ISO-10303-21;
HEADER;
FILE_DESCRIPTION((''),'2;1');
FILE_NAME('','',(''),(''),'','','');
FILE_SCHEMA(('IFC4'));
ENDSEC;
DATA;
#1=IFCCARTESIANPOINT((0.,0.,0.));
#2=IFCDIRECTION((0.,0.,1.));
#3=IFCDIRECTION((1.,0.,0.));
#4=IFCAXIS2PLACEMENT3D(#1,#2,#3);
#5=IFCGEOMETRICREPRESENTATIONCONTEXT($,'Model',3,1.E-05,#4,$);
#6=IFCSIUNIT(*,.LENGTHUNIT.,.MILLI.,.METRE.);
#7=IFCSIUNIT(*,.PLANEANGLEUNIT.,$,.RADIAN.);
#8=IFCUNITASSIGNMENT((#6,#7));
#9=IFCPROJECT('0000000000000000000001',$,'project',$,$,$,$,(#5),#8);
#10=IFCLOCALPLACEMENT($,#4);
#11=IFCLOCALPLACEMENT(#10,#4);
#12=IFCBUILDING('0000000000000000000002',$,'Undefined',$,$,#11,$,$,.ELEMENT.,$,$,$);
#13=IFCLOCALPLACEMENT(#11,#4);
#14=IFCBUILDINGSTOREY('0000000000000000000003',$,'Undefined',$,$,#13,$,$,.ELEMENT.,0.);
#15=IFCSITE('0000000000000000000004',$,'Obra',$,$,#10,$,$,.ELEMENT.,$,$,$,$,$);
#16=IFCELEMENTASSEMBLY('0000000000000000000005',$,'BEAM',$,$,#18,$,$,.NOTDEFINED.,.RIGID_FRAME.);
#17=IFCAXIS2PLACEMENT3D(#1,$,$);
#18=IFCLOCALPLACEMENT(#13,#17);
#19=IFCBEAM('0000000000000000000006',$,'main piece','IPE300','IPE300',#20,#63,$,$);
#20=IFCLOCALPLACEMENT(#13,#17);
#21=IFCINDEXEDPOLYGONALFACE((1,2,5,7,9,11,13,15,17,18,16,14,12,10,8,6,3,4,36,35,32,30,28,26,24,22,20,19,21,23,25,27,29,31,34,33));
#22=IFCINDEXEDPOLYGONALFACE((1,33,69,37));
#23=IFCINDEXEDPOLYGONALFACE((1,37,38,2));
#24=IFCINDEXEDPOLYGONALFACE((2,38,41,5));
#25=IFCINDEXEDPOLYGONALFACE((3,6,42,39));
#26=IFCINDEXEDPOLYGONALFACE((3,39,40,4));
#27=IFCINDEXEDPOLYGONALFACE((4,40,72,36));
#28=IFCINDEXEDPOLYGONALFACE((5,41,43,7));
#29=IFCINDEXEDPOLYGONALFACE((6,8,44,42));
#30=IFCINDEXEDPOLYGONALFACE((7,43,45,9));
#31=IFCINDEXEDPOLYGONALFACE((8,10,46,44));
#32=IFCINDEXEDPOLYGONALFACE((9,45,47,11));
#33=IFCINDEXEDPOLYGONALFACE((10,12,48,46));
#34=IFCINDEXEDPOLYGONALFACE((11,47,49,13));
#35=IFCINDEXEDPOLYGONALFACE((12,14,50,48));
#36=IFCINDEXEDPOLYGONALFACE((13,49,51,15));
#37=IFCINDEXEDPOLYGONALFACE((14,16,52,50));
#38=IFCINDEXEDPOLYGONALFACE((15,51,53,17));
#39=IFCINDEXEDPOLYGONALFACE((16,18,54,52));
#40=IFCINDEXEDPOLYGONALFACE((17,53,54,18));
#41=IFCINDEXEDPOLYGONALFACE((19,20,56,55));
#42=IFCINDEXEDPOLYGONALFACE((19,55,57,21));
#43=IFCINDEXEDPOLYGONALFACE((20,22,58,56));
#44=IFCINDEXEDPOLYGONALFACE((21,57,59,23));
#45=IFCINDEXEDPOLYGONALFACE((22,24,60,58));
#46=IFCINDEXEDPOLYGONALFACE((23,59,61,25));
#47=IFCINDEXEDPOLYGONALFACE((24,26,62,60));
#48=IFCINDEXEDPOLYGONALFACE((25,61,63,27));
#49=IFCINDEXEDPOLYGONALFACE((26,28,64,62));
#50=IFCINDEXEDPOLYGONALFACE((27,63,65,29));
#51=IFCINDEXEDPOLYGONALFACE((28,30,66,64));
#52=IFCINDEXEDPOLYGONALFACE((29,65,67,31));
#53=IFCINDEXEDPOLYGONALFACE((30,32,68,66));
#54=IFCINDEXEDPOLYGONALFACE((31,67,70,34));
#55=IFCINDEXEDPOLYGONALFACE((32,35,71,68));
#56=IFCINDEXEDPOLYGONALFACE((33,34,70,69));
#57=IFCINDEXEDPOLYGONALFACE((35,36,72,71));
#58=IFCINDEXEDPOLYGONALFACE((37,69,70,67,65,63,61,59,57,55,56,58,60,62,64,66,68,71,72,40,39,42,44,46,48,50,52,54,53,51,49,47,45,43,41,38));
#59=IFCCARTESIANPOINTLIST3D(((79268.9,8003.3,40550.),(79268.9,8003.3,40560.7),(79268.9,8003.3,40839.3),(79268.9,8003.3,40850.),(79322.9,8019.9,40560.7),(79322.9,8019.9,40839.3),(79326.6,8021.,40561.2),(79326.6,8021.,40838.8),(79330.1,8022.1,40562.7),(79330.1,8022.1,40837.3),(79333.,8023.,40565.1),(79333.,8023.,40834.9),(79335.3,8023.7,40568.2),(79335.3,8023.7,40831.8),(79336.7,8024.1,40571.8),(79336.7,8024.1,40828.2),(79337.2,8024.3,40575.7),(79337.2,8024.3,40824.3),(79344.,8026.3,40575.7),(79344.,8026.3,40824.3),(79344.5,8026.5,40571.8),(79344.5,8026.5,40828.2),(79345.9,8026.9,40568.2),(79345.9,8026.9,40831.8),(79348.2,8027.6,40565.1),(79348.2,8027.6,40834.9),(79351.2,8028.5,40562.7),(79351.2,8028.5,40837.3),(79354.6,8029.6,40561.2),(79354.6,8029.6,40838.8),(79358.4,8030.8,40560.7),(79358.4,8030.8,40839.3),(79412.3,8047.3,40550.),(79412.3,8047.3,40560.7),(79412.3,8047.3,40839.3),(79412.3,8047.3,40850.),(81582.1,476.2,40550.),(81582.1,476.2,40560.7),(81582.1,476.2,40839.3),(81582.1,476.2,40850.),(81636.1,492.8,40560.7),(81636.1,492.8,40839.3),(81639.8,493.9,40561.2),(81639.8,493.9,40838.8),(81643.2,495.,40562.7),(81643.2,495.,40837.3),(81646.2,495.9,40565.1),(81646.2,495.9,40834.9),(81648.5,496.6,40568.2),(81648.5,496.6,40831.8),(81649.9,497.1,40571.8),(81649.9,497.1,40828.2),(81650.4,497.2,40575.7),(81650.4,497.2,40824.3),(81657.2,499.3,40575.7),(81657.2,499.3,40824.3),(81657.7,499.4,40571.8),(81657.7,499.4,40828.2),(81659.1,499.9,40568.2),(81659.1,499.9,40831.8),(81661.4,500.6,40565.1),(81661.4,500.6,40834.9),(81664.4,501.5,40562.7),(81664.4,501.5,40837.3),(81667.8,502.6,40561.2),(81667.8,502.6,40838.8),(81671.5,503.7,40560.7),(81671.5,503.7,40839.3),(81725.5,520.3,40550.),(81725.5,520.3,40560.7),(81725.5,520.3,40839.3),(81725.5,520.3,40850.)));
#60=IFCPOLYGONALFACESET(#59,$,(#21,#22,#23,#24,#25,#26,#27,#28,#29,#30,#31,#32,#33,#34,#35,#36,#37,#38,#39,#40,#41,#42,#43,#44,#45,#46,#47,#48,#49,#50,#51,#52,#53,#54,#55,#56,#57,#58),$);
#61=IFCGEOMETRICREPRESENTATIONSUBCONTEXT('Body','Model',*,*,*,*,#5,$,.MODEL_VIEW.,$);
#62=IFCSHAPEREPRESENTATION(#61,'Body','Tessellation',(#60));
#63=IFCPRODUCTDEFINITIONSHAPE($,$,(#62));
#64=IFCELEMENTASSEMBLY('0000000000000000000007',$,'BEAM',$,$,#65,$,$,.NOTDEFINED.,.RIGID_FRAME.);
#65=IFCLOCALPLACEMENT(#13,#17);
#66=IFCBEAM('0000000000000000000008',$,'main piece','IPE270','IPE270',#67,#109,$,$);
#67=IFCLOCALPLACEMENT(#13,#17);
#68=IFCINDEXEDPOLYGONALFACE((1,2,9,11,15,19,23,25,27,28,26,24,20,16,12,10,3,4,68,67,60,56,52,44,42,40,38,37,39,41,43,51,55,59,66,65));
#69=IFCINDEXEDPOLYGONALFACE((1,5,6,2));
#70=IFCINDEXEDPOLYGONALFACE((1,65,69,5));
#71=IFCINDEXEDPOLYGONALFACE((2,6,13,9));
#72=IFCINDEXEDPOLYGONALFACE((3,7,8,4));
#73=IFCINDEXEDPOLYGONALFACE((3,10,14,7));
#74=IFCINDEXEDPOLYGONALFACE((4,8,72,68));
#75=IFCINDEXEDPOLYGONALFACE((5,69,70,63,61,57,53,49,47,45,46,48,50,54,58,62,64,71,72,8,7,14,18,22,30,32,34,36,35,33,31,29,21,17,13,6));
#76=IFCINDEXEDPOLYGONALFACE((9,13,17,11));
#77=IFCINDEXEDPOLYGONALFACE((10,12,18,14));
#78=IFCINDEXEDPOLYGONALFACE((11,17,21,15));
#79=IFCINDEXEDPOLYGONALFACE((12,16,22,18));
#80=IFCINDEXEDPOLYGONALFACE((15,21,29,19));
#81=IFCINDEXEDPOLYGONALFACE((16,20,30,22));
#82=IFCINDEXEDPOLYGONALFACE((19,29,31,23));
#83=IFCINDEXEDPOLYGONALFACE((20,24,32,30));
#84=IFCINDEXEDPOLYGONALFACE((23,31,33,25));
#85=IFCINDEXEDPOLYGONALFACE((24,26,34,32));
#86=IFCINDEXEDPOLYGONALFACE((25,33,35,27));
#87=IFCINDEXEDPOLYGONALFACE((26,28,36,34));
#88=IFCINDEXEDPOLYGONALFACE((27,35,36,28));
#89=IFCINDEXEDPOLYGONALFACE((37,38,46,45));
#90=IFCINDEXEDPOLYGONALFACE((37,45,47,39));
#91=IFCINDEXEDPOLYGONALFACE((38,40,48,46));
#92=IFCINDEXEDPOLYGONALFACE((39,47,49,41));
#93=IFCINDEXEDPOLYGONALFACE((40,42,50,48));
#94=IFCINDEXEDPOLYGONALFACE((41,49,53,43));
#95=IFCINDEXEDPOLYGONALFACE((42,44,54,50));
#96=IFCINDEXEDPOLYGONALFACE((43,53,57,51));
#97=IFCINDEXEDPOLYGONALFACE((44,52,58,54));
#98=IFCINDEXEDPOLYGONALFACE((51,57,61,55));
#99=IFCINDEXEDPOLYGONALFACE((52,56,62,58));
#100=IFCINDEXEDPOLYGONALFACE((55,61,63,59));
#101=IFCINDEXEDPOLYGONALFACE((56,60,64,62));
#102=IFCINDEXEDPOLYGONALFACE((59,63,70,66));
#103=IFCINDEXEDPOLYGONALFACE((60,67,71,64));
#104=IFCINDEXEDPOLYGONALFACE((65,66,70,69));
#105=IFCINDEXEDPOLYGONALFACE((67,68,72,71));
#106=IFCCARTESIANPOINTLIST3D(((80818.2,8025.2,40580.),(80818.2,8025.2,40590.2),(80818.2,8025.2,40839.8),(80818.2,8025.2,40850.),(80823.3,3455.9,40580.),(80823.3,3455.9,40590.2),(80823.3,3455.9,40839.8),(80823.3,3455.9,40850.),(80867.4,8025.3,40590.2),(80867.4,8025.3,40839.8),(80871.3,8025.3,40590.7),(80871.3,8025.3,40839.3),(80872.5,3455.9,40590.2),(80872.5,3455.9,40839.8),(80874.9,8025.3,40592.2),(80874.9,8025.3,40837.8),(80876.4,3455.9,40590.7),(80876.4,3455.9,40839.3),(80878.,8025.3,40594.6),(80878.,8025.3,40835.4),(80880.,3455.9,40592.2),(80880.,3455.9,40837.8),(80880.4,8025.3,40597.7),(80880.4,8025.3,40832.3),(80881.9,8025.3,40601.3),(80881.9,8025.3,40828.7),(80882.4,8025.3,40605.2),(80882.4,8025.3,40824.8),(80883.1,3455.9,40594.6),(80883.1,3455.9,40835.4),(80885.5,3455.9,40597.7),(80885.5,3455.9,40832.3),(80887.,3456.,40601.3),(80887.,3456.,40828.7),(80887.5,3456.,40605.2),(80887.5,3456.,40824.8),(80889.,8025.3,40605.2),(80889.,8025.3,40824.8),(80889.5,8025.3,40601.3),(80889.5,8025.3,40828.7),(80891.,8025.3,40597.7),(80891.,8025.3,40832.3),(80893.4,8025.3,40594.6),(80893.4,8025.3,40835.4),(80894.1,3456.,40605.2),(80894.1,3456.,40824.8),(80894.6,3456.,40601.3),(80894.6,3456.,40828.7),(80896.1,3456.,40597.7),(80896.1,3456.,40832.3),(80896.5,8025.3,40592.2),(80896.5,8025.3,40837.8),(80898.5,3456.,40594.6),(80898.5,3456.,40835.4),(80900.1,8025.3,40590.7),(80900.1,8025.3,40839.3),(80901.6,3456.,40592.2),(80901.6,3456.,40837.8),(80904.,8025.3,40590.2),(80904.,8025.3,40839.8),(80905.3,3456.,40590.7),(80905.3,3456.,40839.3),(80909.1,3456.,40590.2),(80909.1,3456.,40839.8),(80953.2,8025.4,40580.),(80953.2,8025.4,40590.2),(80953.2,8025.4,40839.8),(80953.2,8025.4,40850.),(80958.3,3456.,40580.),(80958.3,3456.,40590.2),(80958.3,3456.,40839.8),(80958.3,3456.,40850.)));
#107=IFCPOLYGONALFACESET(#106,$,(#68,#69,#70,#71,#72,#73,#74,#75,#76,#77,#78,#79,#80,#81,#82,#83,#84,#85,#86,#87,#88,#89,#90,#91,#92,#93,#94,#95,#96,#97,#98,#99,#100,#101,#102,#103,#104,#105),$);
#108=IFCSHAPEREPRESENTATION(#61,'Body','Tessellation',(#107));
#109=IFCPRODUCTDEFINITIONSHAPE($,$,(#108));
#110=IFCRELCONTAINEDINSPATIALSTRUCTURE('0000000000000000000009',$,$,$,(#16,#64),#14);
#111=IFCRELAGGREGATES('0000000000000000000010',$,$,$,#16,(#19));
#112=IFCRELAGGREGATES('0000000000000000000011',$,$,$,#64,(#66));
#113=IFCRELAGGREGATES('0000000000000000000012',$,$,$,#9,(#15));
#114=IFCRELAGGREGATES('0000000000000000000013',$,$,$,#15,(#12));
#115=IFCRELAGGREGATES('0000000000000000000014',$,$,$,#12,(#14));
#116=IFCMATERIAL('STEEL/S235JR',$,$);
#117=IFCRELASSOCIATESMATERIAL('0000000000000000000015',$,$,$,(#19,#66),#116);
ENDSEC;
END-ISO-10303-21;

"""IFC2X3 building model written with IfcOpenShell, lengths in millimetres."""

from ifc_helpers import new_model, si_unit, frame, origin_with_axes, origin_2d_with_axis, place, context, subcontext, project, spatial, i_section, extrude, material, element, aggregate, save


model = new_model("IFC2X3")

# Units and contexts
model_context = context("Model", 3, precision=1e-05, world=origin_with_axes())
body_context = subcontext(model_context, "Body", "Model", "MODEL_VIEW")
ifc_project = project(units=[si_unit("LENGTHUNIT", "METRE", prefix="MILLI"), si_unit("PLANEANGLEUNIT", "RADIAN")], contexts=[model_context])

# Site, building, storey
site_placement = place(None, origin_with_axes())
site = spatial("IfcSite", under=ifc_project, at=site_placement, Name="Obra", CompositionType="ELEMENT")
building_placement = place(site_placement, origin_with_axes())
building = spatial("IfcBuilding", under=site, at=building_placement, Name="Undefined", CompositionType="ELEMENT")
storey_placement = place(building_placement, origin_with_axes())
storey = spatial("IfcBuildingStorey", under=building, at=storey_placement, Name="Undefined", CompositionType="ELEMENT", Elevation=0.0)

# Shared definitions
ifc_material_1 = material(Name="STEEL/S235JR")

# Element assemblies, beams
assembly_1_placement = place(storey_placement, origin_with_axes())
assembly_1 = element("IfcElementAssembly", 1, at=assembly_1_placement, inside=storey, Name="BEAM", AssemblyPlace="NOTDEFINED", PredefinedType="RIGID_FRAME")
beam_1_placement = place(assembly_1_placement, frame((79340.6, 8025.3, 40700.0), z_axis=(0.0, 0.0, 1.0), x_axis=(0.293755, -0.955881, 0.0)))
beam_1 = element("IfcBeam", 2, at=beam_1_placement, material=ifc_material_1, Name="main piece", Description="IPE300", ObjectType="IPE300", context=body_context, shape_type="SweptSolid", body=[
    extrude(i_section(OverallWidth=150.0, OverallDepth=300.0, WebThickness=7.1, FlangeThickness=10.7, FilletRadius=15.0, at=origin_2d_with_axis()), frame((7874.5, 0.0, 0.0), z_axis=(-1.0, 0.0, 0.0), x_axis=(0.0, -1.0, 0.0)), (0.0, 0.0, 1.0), 7874.5),
])
aggregate(assembly_1, [beam_1])
assembly_2_placement = place(storey_placement, origin_with_axes())
assembly_2 = element("IfcElementAssembly", 3, at=assembly_2_placement, inside=storey, Name="BEAM", AssemblyPlace="NOTDEFINED", PredefinedType="RIGID_FRAME")
beam_2_placement = place(assembly_2_placement, frame((80890.8, 3456.0, 40715.0), z_axis=(0.0, 0.0, 1.0), x_axis=(-0.001117, 0.999999, 0.0)))
beam_2 = element("IfcBeam", 4, at=beam_2_placement, material=ifc_material_1, Name="main piece", Description="IPE270", ObjectType="IPE270", context=body_context, shape_type="SweptSolid", body=[
    extrude(i_section(OverallWidth=135.0, OverallDepth=270.0, WebThickness=6.6, FlangeThickness=10.2, FilletRadius=15.0, at=origin_2d_with_axis()), frame((4569.3, 0.0, 0.0), z_axis=(-1.0, 0.0, 0.0), x_axis=(0.0, -1.0, 0.0)), (0.0, 0.0, 1.0), 4569.4),
])
aggregate(assembly_2, [beam_2])

save(model, "model.ifc")
